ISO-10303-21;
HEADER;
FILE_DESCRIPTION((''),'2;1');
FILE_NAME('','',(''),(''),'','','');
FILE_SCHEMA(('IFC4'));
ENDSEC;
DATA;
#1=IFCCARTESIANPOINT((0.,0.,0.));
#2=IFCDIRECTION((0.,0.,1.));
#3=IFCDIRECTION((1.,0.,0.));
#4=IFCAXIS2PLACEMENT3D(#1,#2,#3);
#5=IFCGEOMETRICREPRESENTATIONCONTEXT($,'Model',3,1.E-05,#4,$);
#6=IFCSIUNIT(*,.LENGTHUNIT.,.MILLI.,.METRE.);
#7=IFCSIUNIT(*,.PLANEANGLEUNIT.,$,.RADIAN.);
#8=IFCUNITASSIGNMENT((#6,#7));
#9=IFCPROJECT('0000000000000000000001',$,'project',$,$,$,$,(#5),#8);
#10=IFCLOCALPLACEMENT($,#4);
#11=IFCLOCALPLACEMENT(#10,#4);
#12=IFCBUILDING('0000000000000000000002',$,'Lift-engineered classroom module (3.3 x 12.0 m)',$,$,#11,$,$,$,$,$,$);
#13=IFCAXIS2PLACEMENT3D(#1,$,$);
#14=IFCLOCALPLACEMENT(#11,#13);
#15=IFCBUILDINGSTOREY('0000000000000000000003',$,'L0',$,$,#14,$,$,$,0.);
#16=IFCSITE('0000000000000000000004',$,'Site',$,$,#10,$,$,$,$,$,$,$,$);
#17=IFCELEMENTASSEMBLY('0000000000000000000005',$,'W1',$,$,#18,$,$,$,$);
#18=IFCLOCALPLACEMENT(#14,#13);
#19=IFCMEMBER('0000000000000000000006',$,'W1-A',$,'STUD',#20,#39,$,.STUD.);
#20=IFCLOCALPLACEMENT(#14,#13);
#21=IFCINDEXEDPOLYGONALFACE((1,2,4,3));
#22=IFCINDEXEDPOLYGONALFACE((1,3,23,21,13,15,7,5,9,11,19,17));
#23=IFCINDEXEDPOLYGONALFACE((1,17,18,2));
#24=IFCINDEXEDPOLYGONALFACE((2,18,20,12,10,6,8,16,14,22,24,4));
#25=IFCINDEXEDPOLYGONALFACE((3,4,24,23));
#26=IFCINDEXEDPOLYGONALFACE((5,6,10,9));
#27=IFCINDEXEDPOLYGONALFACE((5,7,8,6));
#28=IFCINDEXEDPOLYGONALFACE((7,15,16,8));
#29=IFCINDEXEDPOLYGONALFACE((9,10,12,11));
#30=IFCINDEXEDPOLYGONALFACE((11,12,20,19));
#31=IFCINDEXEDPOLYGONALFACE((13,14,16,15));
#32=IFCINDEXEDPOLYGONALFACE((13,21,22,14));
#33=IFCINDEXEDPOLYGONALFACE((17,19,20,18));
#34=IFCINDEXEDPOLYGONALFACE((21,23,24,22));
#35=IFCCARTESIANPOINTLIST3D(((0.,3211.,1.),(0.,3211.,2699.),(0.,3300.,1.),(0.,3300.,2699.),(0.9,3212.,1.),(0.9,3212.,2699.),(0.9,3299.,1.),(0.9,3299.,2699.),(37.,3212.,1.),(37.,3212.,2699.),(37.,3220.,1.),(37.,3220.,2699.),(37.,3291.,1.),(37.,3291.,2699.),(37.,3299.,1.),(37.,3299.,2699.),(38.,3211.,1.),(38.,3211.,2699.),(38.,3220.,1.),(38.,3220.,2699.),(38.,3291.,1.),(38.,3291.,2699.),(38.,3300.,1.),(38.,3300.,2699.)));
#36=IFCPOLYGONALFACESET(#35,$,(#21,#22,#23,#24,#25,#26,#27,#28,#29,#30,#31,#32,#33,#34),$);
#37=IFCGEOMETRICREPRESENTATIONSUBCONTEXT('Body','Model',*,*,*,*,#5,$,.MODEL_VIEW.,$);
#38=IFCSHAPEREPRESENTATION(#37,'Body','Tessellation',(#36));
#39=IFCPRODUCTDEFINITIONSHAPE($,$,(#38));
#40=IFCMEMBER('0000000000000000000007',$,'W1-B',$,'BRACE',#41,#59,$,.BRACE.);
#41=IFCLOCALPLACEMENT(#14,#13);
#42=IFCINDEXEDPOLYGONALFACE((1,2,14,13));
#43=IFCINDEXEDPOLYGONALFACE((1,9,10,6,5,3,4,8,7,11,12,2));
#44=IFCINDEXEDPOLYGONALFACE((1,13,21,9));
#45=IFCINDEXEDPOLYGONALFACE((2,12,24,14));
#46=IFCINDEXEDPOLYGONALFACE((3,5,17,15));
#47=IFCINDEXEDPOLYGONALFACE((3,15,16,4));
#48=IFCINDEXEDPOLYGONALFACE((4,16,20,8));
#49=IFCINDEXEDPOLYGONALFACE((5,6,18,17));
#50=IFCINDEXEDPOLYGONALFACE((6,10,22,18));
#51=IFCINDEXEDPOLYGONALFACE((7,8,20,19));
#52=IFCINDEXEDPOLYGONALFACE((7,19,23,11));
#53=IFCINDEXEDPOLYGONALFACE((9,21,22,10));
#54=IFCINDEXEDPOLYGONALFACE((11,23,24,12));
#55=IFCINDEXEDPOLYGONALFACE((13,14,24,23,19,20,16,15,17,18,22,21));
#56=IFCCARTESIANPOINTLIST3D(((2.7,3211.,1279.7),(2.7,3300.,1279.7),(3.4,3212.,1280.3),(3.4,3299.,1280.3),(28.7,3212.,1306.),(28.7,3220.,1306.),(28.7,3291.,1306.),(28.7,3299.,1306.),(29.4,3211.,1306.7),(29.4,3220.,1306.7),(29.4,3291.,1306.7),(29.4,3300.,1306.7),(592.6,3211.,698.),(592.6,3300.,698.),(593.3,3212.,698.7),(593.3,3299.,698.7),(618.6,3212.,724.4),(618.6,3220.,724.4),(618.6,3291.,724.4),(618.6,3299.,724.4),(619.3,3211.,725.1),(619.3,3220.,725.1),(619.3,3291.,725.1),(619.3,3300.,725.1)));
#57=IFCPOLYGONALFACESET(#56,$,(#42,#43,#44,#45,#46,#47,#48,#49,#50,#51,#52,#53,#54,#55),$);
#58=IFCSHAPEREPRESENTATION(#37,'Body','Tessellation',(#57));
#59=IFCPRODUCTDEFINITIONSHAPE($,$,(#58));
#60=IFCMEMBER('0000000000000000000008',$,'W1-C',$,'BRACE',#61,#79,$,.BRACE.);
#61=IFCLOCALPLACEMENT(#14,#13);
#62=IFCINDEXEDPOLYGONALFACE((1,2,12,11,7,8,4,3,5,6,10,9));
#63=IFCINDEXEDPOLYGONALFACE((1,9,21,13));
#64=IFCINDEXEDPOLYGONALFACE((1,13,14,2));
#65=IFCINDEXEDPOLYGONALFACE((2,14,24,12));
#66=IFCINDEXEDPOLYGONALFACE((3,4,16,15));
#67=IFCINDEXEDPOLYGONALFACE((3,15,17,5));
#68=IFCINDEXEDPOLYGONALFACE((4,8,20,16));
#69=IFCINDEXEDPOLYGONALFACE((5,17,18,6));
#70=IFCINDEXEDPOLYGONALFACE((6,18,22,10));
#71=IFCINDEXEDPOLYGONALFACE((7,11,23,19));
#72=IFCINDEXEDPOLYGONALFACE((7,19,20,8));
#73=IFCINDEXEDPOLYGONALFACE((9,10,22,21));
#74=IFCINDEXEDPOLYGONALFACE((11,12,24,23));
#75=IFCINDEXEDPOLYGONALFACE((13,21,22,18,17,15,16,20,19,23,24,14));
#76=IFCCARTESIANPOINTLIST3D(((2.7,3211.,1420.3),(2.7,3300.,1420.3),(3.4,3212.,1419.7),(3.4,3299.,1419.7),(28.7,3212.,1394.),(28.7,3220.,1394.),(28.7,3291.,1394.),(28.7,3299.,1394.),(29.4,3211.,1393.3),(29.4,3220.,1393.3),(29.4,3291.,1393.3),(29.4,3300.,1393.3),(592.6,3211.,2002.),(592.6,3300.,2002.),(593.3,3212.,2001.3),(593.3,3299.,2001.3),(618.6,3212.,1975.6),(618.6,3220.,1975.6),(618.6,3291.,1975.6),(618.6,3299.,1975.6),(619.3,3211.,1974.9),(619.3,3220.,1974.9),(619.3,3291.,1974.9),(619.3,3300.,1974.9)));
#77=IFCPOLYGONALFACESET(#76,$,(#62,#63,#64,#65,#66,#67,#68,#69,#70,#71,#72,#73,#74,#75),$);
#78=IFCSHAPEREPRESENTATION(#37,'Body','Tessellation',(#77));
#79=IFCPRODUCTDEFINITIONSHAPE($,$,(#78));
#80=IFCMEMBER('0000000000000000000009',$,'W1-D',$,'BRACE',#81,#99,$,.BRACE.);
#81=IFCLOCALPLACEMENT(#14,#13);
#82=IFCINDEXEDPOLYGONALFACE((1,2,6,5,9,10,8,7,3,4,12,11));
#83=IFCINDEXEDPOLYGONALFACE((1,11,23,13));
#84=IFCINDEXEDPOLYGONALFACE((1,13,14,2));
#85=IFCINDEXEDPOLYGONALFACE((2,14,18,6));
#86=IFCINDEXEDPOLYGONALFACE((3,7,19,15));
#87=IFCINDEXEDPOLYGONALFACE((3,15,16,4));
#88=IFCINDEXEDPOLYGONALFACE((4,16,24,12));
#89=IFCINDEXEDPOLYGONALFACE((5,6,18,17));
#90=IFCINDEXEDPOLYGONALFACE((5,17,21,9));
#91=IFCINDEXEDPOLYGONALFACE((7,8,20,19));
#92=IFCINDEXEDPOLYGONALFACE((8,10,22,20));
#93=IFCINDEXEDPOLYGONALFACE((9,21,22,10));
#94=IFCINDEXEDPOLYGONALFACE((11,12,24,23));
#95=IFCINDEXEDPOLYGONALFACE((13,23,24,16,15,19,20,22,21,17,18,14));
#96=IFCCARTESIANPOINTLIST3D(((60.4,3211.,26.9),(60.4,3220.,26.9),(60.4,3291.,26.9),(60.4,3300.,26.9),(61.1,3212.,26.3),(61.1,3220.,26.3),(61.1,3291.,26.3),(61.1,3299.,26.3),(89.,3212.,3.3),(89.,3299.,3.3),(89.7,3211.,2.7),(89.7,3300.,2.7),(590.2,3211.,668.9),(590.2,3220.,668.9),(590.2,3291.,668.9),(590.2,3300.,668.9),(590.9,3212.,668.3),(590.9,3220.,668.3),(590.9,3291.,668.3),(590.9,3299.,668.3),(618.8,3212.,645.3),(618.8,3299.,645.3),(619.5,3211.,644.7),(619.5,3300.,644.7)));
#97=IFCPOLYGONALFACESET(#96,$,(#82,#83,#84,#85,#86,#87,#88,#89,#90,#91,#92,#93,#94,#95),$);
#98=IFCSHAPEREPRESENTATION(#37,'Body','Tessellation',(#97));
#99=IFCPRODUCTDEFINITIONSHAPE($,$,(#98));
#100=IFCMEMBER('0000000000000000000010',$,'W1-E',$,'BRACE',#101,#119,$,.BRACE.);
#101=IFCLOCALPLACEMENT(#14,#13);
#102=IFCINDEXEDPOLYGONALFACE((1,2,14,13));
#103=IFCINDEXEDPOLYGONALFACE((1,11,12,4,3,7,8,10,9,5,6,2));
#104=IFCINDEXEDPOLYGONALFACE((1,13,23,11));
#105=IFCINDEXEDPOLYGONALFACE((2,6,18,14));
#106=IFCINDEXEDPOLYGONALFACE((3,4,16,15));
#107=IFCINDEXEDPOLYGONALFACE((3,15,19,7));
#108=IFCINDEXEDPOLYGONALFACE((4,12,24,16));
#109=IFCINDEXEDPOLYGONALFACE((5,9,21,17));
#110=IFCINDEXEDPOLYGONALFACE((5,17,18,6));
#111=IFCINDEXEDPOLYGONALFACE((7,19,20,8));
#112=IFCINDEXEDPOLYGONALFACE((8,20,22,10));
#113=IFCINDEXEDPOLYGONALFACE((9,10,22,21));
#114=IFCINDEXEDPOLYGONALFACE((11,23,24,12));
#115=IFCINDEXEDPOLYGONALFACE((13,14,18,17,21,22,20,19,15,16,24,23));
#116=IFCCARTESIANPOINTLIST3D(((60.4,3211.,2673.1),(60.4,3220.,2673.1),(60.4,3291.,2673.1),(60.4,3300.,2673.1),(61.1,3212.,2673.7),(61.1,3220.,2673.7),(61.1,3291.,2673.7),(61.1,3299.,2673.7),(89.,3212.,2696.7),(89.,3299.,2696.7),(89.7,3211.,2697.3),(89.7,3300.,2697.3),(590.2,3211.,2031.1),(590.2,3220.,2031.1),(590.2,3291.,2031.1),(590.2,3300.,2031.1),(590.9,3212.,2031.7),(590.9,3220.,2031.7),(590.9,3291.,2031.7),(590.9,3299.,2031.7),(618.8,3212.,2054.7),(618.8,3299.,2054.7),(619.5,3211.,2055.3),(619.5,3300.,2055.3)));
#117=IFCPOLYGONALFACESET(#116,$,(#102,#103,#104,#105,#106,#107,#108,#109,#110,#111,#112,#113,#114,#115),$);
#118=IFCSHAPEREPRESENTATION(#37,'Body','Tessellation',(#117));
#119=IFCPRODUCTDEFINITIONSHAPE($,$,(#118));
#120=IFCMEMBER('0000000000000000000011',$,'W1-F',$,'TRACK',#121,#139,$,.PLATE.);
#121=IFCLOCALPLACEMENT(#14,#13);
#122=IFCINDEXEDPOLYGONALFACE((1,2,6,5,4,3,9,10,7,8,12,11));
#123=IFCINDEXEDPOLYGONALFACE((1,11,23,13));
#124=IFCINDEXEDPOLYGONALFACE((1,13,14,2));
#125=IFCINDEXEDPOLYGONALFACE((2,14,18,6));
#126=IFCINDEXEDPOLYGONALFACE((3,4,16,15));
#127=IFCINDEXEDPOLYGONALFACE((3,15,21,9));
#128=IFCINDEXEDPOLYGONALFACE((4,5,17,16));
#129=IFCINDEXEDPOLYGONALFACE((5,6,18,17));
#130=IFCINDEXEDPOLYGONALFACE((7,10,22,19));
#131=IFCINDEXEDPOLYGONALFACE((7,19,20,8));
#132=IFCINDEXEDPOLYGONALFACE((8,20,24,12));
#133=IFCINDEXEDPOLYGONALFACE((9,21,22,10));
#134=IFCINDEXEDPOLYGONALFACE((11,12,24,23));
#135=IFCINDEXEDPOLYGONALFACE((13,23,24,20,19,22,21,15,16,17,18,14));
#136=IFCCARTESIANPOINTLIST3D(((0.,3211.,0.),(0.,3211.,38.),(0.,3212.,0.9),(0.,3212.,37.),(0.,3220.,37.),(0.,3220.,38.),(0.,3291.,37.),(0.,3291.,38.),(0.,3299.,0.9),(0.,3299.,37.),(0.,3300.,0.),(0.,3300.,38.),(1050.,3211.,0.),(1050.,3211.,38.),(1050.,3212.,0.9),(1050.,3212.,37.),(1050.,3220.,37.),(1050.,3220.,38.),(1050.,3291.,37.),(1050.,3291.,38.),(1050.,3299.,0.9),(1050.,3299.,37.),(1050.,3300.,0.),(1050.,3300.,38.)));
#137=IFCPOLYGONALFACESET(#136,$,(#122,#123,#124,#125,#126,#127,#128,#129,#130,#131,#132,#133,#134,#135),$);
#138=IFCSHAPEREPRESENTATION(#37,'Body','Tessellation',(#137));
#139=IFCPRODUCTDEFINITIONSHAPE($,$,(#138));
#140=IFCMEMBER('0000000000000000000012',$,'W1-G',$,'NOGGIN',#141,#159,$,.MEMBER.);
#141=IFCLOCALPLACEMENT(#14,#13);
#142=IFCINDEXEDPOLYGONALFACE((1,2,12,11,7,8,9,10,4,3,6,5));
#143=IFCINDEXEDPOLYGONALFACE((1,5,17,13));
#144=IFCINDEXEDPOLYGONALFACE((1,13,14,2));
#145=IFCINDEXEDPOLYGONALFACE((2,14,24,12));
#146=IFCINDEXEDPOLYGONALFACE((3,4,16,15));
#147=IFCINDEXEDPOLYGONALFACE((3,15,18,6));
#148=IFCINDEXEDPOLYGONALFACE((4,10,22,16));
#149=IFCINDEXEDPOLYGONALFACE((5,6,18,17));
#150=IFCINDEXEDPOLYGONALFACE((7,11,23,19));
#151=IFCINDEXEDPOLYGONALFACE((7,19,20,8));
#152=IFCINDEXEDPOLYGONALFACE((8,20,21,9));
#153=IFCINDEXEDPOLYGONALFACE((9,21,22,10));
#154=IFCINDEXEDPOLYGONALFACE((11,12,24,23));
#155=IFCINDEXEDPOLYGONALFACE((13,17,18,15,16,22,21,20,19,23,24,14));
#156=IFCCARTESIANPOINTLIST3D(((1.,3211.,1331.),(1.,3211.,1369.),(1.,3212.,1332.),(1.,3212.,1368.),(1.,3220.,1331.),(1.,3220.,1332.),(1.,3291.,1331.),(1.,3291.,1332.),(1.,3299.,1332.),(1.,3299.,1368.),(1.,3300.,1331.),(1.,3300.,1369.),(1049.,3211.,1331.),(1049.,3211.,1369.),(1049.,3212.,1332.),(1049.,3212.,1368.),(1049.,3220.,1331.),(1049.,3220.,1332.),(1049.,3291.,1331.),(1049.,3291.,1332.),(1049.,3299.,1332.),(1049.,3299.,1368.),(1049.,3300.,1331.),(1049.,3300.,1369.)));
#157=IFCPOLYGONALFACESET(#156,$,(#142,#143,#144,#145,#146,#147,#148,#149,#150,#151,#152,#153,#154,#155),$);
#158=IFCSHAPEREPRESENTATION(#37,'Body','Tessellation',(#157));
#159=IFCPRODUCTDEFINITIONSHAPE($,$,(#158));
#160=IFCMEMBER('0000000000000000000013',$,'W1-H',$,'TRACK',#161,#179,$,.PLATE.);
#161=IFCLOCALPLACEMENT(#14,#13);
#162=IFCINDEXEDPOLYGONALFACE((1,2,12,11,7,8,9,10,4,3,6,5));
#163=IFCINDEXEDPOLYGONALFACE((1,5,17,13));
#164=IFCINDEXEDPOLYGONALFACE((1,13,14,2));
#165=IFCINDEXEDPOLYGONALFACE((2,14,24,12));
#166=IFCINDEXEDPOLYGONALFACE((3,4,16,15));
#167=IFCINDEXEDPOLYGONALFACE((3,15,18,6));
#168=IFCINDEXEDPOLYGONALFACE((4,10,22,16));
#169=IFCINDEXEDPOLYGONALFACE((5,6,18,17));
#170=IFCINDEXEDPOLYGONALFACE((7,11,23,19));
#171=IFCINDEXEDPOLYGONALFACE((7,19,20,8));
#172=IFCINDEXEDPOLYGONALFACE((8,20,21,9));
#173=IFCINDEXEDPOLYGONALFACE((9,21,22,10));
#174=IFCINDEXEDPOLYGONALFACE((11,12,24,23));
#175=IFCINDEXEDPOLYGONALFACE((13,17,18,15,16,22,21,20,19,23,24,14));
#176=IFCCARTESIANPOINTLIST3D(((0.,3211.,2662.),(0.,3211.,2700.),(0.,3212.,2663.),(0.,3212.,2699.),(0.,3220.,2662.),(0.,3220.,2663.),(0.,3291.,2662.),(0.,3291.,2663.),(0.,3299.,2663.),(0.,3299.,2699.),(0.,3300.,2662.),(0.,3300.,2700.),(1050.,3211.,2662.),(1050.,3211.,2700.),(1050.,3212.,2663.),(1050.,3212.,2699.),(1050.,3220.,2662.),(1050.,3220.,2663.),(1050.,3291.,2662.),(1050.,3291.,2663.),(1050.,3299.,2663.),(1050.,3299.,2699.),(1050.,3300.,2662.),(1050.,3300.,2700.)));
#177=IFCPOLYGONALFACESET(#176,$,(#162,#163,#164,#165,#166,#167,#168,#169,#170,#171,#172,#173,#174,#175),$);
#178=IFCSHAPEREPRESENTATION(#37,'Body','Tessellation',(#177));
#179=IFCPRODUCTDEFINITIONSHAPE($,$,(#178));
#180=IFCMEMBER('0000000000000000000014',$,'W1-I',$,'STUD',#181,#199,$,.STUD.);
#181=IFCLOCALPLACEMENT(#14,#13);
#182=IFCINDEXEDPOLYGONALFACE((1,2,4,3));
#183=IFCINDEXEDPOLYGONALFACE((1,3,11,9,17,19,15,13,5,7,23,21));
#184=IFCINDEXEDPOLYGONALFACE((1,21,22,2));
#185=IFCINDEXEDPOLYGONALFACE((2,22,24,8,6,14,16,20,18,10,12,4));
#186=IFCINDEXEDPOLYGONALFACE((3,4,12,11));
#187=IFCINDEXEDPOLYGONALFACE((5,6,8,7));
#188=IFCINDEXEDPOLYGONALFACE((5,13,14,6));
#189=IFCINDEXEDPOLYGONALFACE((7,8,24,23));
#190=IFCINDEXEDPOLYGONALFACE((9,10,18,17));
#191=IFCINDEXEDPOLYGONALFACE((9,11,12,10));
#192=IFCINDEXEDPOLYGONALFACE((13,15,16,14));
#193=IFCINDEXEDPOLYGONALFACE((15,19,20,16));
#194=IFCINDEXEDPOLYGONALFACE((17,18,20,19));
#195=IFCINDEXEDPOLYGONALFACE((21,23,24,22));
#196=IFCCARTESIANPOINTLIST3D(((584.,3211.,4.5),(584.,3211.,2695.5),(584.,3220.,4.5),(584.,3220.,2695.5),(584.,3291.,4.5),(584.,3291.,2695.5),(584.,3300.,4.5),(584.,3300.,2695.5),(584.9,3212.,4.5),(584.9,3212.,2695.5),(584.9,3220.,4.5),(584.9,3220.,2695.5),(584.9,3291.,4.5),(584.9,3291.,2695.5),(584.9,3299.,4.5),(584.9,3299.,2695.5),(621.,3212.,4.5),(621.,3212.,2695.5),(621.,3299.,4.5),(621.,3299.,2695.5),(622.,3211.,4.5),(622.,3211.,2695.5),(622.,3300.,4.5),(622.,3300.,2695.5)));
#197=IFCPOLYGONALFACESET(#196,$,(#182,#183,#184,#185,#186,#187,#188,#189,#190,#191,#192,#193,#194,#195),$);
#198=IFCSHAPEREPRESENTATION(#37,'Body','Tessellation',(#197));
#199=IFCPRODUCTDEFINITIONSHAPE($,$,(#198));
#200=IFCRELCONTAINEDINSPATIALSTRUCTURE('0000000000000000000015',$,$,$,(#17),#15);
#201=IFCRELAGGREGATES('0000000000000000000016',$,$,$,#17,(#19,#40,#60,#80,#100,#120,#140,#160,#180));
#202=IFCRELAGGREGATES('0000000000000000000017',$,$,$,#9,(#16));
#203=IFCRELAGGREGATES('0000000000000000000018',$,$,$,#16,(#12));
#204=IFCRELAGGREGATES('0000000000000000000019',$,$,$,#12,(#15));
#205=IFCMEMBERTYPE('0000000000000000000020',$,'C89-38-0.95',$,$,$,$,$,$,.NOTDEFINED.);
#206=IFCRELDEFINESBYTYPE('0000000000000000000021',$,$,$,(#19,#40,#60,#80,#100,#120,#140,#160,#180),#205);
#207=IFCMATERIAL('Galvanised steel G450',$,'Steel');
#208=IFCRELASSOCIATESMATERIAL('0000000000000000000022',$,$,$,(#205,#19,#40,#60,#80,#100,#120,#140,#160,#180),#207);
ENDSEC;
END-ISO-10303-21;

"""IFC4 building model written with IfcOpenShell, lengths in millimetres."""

from ifc_helpers import new_model, si_unit, frame, origin, origin_with_axes, origin_2d, place, context, subcontext, project, spatial, c_section, extrude, material, material_profile, profile_set, profile_usage, type_object, element, aggregate, save


model = new_model("IFC4")

# Units and contexts
model_context = context("Model", 3, precision=1e-05, world=origin_with_axes())
body_context = subcontext(model_context, "Body", "Model", "MODEL_VIEW")
ifc_project = project(units=[si_unit("LENGTHUNIT", "METRE", prefix="MILLI"), si_unit("PLANEANGLEUNIT", "RADIAN")], contexts=[model_context])

# Site, building, storey
site_placement = place(None, origin_with_axes())
site = spatial("IfcSite", under=ifc_project, at=site_placement, Name="Site")
building_placement = place(site_placement, origin_with_axes())
building = spatial("IfcBuilding", under=site, at=building_placement, Name="Lift-engineered classroom module (3.3 x 12.0 m)")
storey_placement = place(building_placement, origin())
storey = spatial("IfcBuildingStorey", under=building, at=storey_placement, Name="L0", Elevation=0.0)

# Element assembly, members
assembly_1_placement = place(storey_placement, frame((0.0, 3255.5, 0.0)))
assembly_1 = element("IfcElementAssembly", 1, at=assembly_1_placement, inside=storey, Name="W1")
ifc_material = material(Name="Galvanised steel G450", Category="Steel")
ifc_material_profile = material_profile(ifc_material, c_section(Depth=89.0, Width=38.0, WallThickness=0.9, Girth=9.0, at=origin_2d()), Name="C89-38-0.95")
ifc_profile_set = profile_set([ifc_material_profile], Name="C89-38-0.95")
ifc_profile_usage = profile_usage(ifc_profile_set)
member_type = type_object("IfcMemberType", Name="C89-38-0.95", PredefinedType="NOTDEFINED", material=ifc_profile_set)
member_1_placement = place(assembly_1_placement, frame((19.0, 0.0, 2699.1), z_axis=(0.0, 0.0, -1.0), x_axis=(1.0, 0.0, 0.0)))
member_1 = element("IfcMember", 2, at=member_1_placement, type_object=member_type, material=ifc_profile_usage, Name="W1-A", ObjectType="STUD", PredefinedType="STUD", context=body_context, shape_type="SweptSolid", body=[
    extrude(c_section(Depth=89.0, Width=38.0, WallThickness=0.9, Girth=9.0, at=origin_2d()), origin(), (0.0, 0.0, 1.0), 2698.1),
])
member_2_placement = place(assembly_1_placement, frame((16.0, 0.0, 1293.2), z_axis=(0.712068, 0.0, -0.70211), x_axis=(0.70211, 0.0, 0.712068)))
member_2 = element("IfcMember", 3, at=member_2_placement, type_object=member_type, material=ifc_profile_usage, Name="W1-B", ObjectType="BRACE", PredefinedType="BRACE", context=body_context, shape_type="SweptSolid", body=[
    extrude(c_section(Depth=89.0, Width=38.0, WallThickness=0.9, Girth=9.0, at=origin_2d()), origin(), (0.0, 0.0, 1.0), 828.5),
])
member_3_placement = place(assembly_1_placement, frame((606.0, 0.0, 1988.5), z_axis=(-0.712068, 0.0, -0.70211), x_axis=(0.70211, 0.0, -0.712068)))
member_3 = element("IfcMember", 4, at=member_3_placement, type_object=member_type, material=ifc_profile_usage, Name="W1-C", ObjectType="BRACE", PredefinedType="BRACE", context=body_context, shape_type="SweptSolid", body=[
    extrude(c_section(Depth=89.0, Width=38.0, WallThickness=0.9, Girth=9.0, at=origin_2d()), origin(), (0.0, 0.0, 1.0), 828.5),
])
member_4_placement = place(assembly_1_placement, frame((75.0, 0.0, 14.8), z_axis=(0.636508, 0.0, 0.77127), x_axis=(-0.77127, 0.0, 0.636508)))
member_4 = element("IfcMember", 5, at=member_4_placement, type_object=member_type, material=ifc_profile_usage, Name="W1-D", ObjectType="BRACE", PredefinedType="BRACE", context=body_context, shape_type="SweptSolid", body=[
    extrude(c_section(Depth=89.0, Width=38.0, WallThickness=0.9, Girth=9.0, at=origin_2d()), origin(), (0.0, 0.0, 1.0), 832.4),
])
member_5_placement = place(assembly_1_placement, frame((604.8, 0.0, 2043.2), z_axis=(-0.636508, 0.0, 0.77127), x_axis=(-0.77127, 0.0, -0.636508)))
member_5 = element("IfcMember", 6, at=member_5_placement, type_object=member_type, material=ifc_profile_usage, Name="W1-E", ObjectType="BRACE", PredefinedType="BRACE", context=body_context, shape_type="SweptSolid", body=[
    extrude(c_section(Depth=89.0, Width=38.0, WallThickness=0.9, Girth=9.0, at=origin_2d()), origin(), (0.0, 0.0, 1.0), 832.4),
])
member_6_placement = place(assembly_1_placement, frame((0.0, 0.0, 19.0), z_axis=(1.0, 0.0, 0.0), x_axis=(0.0, 0.0, 1.0)))
member_6 = element("IfcMember", 7, at=member_6_placement, type_object=member_type, material=ifc_profile_usage, Name="W1-F", ObjectType="TRACK", PredefinedType="PLATE", context=body_context, shape_type="SweptSolid", body=[
    extrude(c_section(Depth=89.0, Width=38.0, WallThickness=0.9, Girth=9.0, at=origin_2d()), origin(), (0.0, 0.0, 1.0), 1050.0),
])
member_7_placement = place(assembly_1_placement, frame((1049.0, 0.0, 1350.0), z_axis=(-1.0, 0.0, 0.0), x_axis=(0.0, 0.0, -1.0)))
member_7 = element("IfcMember", 8, at=member_7_placement, type_object=member_type, material=ifc_profile_usage, Name="W1-G", ObjectType="NOGGIN", PredefinedType="MEMBER", context=body_context, shape_type="SweptSolid", body=[
    extrude(c_section(Depth=89.0, Width=38.0, WallThickness=0.9, Girth=9.0, at=origin_2d()), origin(), (0.0, 0.0, 1.0), 1048.1),
])
member_8_placement = place(assembly_1_placement, frame((1050.0, 0.0, 2681.0), z_axis=(-1.0, 0.0, 0.0), x_axis=(0.0, 0.0, -1.0)))
member_8 = element("IfcMember", 9, at=member_8_placement, type_object=member_type, material=ifc_profile_usage, Name="W1-H", ObjectType="TRACK", PredefinedType="PLATE", context=body_context, shape_type="SweptSolid", body=[
    extrude(c_section(Depth=89.0, Width=38.0, WallThickness=0.9, Girth=9.0, at=origin_2d()), origin(), (0.0, 0.0, 1.0), 1050.0),
])
member_9_placement = place(assembly_1_placement, frame((603.0, 0.0, 4.5), z_axis=(0.0, 0.0, 1.0), x_axis=(-1.0, 0.0, 0.0)))
member_9 = element("IfcMember", 10, at=member_9_placement, type_object=member_type, material=ifc_profile_usage, Name="W1-I", ObjectType="STUD", PredefinedType="STUD", context=body_context, shape_type="SweptSolid", body=[
    extrude(c_section(Depth=89.0, Width=38.0, WallThickness=0.9, Girth=9.0, at=origin_2d()), origin(), (0.0, 0.0, 1.0), 2691.0),
])
aggregate(assembly_1, [member_1, member_2, member_3, member_4, member_5, member_6, member_7, member_8, member_9])

save(model, "model.ifc")
